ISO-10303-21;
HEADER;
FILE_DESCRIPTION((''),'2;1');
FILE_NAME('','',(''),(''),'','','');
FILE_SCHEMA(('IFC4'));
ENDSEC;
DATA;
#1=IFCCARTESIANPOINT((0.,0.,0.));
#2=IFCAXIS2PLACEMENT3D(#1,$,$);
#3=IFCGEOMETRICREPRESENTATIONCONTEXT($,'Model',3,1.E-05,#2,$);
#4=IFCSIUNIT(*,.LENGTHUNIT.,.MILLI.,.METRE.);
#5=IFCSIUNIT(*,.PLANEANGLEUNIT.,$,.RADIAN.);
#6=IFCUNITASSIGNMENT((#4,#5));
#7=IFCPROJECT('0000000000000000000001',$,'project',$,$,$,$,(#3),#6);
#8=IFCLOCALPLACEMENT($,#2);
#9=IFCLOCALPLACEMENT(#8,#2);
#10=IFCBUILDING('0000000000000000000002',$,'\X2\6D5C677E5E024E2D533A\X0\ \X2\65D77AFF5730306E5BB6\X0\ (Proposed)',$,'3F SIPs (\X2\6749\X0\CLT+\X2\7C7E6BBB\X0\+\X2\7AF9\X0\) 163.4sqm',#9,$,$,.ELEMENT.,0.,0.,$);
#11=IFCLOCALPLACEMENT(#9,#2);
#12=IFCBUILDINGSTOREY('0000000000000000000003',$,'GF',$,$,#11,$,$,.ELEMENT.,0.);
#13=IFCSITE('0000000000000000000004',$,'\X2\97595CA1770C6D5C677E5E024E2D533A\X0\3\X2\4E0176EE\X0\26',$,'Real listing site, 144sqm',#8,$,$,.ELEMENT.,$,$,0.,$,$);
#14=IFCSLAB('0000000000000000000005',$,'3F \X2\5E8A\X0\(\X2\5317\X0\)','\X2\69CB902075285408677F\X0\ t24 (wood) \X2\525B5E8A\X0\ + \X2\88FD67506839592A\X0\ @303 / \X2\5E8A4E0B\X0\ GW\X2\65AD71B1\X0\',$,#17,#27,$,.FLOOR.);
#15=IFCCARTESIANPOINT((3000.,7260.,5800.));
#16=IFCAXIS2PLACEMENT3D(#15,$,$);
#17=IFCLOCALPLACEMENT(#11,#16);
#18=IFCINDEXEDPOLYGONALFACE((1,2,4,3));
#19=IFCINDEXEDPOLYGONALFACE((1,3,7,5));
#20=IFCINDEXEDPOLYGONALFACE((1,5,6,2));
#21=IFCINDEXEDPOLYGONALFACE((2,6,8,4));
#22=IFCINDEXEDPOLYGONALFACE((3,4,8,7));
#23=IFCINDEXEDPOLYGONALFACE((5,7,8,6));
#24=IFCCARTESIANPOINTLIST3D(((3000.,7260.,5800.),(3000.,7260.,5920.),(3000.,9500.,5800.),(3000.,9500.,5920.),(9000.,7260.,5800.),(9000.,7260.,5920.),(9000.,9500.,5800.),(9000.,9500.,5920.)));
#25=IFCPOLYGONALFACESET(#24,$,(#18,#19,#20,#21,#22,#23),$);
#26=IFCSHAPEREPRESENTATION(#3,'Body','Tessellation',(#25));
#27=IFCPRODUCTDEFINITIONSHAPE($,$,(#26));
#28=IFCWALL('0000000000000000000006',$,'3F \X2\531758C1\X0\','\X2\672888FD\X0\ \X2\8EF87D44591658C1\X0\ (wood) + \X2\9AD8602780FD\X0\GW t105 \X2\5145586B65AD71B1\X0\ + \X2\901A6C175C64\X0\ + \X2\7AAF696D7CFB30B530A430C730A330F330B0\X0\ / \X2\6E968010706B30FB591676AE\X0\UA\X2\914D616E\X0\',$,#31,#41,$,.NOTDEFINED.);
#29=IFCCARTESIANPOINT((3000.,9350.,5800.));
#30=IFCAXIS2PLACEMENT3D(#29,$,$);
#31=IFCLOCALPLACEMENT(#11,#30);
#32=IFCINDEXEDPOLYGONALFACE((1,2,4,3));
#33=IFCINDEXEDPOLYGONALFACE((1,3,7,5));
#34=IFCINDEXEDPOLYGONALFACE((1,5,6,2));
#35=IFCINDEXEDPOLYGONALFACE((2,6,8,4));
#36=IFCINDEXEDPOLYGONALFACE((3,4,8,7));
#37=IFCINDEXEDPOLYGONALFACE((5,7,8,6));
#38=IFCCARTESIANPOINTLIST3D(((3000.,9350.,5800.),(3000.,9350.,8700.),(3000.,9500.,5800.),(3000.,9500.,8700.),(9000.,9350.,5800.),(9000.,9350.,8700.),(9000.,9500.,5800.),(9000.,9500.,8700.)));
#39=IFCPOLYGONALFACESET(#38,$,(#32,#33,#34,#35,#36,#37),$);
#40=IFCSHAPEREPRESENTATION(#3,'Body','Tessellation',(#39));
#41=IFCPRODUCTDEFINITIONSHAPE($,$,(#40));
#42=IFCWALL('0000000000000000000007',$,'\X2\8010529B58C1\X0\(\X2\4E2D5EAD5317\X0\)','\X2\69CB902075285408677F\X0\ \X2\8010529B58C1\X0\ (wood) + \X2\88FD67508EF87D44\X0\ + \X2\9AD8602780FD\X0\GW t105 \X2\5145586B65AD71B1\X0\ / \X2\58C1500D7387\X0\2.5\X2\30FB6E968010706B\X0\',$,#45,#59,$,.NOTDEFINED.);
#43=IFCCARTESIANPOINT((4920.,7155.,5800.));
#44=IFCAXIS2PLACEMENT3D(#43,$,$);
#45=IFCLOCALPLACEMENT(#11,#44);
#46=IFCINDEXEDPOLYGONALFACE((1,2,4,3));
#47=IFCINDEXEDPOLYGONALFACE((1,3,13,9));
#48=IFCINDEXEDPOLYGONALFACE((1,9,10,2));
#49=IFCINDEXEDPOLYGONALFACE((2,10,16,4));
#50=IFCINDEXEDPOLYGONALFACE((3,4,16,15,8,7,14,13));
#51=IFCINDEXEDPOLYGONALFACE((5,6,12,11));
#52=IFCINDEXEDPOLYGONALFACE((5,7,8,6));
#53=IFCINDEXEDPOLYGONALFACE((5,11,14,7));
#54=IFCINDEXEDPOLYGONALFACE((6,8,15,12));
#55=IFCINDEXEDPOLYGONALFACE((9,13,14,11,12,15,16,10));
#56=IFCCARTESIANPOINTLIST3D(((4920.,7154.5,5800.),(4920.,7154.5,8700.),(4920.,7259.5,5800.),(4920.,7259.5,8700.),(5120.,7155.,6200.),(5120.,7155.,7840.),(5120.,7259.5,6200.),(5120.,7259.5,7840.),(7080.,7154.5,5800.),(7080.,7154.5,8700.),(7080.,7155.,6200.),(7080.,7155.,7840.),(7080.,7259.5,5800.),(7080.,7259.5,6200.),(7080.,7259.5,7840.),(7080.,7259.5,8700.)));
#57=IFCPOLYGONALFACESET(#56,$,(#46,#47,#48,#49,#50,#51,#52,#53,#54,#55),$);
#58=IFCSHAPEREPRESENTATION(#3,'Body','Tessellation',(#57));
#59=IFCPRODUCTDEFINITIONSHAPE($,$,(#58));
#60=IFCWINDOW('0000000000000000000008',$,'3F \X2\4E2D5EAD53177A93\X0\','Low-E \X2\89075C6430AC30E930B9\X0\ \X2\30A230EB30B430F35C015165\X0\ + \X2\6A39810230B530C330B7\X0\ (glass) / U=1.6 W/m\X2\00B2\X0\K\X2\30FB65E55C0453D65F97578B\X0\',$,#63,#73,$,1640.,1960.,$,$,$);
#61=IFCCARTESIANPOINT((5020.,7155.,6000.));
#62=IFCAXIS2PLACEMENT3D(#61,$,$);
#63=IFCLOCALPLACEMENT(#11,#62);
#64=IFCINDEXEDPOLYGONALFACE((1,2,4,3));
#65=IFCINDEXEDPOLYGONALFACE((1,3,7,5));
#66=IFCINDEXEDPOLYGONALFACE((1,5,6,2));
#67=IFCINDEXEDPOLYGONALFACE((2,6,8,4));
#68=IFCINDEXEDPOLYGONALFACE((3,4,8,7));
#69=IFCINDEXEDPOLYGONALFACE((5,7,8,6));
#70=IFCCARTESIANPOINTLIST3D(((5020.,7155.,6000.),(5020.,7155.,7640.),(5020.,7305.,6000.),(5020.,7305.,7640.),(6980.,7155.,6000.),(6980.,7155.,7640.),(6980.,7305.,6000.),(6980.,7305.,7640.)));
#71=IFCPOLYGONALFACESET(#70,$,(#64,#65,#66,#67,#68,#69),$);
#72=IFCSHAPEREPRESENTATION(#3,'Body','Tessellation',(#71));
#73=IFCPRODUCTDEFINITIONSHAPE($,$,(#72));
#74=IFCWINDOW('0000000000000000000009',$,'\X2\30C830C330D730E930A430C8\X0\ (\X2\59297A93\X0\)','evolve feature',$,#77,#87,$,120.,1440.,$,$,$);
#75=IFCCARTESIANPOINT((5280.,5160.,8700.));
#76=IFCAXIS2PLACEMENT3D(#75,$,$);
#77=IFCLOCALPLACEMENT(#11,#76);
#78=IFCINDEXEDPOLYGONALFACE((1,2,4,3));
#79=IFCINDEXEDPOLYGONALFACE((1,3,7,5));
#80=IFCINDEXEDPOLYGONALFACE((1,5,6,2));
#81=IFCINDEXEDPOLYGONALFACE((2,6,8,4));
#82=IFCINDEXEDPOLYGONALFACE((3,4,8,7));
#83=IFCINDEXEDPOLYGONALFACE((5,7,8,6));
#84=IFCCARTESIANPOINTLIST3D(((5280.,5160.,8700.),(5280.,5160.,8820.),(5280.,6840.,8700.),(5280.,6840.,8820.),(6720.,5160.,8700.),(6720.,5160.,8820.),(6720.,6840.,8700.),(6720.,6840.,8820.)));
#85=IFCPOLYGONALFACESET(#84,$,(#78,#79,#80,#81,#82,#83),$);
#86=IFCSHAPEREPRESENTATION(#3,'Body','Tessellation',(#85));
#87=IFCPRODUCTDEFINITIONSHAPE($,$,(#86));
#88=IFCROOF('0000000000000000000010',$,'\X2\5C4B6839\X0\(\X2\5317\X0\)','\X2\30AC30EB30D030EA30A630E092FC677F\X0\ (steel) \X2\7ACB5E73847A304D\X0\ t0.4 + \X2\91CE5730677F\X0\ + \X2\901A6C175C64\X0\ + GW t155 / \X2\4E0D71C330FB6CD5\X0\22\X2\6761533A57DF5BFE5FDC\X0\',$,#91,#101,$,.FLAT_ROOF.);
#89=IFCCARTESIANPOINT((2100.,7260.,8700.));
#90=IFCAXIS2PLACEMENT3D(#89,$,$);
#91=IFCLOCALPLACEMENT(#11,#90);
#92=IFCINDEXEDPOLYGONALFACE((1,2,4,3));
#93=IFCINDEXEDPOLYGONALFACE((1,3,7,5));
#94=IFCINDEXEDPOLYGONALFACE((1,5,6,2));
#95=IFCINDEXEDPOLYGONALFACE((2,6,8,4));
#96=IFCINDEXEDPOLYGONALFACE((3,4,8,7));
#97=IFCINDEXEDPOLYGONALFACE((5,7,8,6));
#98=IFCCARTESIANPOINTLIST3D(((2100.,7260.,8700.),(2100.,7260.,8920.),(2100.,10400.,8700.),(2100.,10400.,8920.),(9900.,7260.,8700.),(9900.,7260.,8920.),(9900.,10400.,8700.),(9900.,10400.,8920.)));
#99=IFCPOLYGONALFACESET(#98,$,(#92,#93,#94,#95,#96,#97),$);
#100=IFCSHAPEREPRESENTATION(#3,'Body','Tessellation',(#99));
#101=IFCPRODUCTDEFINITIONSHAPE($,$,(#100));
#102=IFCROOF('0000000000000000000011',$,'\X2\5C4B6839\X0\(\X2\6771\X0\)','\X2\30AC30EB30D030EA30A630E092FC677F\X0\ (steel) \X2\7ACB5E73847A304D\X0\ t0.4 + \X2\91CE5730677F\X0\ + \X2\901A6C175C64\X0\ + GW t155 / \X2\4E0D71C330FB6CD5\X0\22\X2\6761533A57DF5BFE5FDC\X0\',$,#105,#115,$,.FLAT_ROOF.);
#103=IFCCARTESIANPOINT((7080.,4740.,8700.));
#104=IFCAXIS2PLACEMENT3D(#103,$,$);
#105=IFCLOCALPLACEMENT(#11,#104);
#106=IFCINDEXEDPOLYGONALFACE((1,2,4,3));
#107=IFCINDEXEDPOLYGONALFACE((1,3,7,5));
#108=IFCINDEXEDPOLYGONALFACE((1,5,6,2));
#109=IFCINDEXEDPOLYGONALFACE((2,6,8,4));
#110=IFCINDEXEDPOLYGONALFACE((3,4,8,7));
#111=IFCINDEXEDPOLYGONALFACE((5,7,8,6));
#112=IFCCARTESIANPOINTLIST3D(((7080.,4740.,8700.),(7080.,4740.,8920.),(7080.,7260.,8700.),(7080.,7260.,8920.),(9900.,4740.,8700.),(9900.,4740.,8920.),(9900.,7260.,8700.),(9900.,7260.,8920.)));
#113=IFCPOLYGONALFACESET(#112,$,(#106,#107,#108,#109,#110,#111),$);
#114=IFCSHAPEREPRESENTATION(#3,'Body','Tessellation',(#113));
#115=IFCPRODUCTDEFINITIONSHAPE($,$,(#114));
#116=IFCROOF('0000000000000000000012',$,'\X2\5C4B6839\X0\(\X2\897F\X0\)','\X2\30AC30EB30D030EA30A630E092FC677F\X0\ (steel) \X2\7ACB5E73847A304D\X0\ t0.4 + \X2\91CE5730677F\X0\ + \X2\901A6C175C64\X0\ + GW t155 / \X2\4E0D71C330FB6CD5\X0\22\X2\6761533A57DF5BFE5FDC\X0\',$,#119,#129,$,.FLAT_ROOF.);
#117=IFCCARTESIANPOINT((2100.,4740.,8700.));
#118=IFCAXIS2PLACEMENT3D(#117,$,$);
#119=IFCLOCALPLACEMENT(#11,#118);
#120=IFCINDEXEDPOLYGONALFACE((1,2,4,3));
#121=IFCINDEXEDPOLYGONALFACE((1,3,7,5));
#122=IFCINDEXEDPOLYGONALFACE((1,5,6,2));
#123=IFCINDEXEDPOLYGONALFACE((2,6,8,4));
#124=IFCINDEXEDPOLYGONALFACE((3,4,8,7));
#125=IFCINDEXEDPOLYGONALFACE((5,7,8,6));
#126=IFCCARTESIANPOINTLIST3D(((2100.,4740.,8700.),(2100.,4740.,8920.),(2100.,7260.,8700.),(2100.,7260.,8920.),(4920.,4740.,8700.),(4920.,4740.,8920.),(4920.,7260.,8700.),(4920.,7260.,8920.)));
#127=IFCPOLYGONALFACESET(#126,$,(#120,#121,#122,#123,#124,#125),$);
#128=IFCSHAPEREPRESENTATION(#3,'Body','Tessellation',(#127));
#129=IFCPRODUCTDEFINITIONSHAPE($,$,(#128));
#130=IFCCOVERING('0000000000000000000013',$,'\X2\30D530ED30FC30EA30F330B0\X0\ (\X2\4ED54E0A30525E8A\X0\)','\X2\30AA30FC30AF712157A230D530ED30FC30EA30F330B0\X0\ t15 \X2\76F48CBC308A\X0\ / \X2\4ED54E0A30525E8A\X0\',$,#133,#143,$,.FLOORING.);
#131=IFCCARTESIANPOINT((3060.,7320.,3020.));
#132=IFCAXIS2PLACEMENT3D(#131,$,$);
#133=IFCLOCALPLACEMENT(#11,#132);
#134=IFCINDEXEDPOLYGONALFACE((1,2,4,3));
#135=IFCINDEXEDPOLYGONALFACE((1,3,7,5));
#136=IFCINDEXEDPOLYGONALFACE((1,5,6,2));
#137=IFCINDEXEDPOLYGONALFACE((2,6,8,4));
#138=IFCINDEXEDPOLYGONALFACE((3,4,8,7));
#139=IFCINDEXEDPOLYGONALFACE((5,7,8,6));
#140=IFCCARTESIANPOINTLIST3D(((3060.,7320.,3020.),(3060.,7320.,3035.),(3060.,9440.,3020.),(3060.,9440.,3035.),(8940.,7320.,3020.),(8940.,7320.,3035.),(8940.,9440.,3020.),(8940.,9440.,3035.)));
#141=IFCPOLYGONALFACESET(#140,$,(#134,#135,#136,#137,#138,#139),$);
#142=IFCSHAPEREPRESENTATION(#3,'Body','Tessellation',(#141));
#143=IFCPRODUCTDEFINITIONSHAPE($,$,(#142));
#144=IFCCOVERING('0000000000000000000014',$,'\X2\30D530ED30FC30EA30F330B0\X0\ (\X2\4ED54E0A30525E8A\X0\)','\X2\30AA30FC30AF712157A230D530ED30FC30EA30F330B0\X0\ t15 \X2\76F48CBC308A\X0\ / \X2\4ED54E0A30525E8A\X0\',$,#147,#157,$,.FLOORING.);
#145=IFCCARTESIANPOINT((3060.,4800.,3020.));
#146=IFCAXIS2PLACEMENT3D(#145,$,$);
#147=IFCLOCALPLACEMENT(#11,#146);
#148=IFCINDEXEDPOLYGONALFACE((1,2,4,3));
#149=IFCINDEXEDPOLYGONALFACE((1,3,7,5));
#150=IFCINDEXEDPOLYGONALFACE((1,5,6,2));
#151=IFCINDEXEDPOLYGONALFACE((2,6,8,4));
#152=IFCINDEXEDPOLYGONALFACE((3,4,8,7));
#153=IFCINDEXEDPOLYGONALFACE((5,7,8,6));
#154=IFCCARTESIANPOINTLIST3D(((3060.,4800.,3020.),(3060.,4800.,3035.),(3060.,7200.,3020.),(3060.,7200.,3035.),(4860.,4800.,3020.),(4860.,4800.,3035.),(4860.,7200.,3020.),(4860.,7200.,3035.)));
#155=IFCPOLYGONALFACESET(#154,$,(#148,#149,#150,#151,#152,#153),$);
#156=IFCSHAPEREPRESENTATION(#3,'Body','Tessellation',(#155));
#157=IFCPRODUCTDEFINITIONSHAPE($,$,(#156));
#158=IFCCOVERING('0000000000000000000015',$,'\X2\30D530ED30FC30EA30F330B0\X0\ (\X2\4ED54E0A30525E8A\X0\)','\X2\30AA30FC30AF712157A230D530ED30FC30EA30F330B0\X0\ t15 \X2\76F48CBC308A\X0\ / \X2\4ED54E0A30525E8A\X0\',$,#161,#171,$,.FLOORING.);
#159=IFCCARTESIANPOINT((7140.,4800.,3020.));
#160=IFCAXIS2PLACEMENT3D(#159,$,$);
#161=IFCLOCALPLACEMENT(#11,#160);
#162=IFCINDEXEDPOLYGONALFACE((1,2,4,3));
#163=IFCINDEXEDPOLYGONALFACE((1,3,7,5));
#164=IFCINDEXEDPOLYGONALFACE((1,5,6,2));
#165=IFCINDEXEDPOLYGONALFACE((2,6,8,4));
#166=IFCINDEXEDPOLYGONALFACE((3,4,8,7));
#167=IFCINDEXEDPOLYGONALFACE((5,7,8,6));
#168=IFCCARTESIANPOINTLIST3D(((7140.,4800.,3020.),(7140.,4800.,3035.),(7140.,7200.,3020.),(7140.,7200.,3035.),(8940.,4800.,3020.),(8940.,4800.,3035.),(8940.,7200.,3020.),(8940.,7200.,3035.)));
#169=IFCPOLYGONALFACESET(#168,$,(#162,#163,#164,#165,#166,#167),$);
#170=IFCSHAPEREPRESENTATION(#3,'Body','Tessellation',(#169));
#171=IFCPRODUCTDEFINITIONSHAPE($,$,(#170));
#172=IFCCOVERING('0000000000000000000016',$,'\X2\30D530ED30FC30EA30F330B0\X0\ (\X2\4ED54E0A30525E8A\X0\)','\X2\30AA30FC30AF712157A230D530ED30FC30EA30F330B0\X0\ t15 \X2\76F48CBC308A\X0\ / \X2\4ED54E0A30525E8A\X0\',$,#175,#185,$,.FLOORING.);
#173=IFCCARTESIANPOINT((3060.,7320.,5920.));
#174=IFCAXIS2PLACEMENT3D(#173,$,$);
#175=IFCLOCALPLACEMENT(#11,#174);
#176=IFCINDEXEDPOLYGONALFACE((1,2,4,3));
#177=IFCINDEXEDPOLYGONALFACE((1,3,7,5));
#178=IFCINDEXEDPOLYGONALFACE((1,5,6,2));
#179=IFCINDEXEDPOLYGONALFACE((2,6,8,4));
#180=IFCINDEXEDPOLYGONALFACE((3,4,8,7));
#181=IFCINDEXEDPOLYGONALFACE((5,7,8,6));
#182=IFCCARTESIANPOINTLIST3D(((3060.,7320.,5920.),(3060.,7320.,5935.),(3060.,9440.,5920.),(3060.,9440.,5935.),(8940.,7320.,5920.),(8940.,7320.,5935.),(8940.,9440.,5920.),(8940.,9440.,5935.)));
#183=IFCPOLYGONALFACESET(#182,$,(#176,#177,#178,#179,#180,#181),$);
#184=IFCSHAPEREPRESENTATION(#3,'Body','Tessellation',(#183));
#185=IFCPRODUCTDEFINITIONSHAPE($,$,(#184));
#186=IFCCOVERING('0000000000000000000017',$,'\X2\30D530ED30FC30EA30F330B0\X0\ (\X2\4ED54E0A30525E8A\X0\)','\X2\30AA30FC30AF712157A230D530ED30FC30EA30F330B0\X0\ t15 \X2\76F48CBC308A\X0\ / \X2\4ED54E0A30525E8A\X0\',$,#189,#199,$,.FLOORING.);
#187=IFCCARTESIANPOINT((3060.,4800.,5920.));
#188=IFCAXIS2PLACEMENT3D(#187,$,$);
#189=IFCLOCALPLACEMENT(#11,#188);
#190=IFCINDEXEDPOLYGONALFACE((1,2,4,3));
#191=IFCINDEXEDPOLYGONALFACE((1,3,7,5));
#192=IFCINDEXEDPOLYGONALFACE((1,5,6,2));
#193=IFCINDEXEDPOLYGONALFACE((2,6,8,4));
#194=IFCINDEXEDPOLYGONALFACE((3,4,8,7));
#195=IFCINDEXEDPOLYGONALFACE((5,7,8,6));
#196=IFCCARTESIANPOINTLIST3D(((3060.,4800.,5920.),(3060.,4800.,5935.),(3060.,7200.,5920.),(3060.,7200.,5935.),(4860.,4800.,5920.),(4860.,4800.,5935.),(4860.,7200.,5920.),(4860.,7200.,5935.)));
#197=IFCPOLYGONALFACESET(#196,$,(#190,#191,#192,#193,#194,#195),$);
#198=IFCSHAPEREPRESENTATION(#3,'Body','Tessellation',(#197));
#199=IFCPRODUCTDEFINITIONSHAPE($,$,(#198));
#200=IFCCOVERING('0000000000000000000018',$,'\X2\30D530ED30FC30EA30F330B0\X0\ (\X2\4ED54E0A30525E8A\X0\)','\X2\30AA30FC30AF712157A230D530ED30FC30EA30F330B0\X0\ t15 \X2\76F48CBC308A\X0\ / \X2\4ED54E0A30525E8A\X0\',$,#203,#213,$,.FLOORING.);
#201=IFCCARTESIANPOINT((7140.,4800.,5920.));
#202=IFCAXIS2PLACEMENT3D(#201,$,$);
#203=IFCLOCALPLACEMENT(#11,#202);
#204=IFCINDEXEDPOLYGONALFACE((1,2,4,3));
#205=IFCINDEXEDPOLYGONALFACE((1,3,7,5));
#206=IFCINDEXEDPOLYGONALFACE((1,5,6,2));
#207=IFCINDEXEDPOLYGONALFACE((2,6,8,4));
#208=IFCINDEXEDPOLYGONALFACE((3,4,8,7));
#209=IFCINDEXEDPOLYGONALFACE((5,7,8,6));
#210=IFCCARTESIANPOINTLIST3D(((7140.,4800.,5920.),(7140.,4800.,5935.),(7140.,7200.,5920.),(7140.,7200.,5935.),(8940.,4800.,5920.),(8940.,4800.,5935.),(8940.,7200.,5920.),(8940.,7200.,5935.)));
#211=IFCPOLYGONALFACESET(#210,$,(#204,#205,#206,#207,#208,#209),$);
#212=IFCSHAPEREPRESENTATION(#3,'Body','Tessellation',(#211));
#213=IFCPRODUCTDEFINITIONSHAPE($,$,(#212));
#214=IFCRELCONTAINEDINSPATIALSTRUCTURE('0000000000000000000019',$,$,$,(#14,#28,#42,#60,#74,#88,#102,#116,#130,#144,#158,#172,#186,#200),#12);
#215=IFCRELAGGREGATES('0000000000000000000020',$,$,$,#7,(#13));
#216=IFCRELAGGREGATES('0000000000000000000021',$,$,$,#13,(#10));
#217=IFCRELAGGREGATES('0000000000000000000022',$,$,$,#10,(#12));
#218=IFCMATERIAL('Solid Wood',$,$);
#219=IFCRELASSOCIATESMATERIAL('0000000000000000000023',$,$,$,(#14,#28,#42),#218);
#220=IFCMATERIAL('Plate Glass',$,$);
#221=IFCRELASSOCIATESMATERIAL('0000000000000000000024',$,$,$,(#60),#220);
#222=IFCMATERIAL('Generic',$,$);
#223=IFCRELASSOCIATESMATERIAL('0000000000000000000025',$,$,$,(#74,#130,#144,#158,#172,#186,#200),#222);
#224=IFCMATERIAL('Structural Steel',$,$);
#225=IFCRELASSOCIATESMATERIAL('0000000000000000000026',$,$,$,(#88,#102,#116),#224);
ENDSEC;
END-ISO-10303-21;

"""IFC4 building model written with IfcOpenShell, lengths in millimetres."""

from ifc_helpers import new_model, si_unit, frame, frame_2d, origin, place, context, project, spatial, rectangle, extrude, material, element, fill, save


model = new_model("IFC4")

# Units and contexts
model_context = context("Model", 3, precision=1e-05, world=origin())
ifc_project = project(units=[si_unit("LENGTHUNIT", "METRE", prefix="MILLI"), si_unit("PLANEANGLEUNIT", "RADIAN")], contexts=[model_context])

# Site, building, storey
site_placement = place(None, origin())
site = spatial("IfcSite", under=ifc_project, at=site_placement, Name="静岡県浜松市中区3丁目26", ObjectType="Real listing site, 144sqm", CompositionType="ELEMENT", RefElevation=0.0)
building_placement = place(site_placement, origin())
building = spatial("IfcBuilding", under=site, at=building_placement, Name="浜松市中区 旗竿地の家 (Proposed)", ObjectType="3F SIPs (杉CLT+籾殻+竹) 163.4sqm", CompositionType="ELEMENT", ElevationOfRefHeight=0.0, ElevationOfTerrain=0.0)
storey_placement = place(building_placement, origin())
storey = spatial("IfcBuildingStorey", under=building, at=storey_placement, Name="GF", CompositionType="ELEMENT", Elevation=0.0)

# Slab
ifc_material_1 = material(Name="Solid Wood")
slab_placement = place(storey_placement, frame((3000.0, 7260.0, 5800.0)))
element("IfcSlab", 1, at=slab_placement, inside=storey, material=ifc_material_1, Name="3F 床(北)", Description="構造用合板 t24 (wood) 剛床 + 製材根太 @303 / 床下 GW断熱", PredefinedType="FLOOR", context=model_context, shape_type="SweptSolid", body=[
    extrude(rectangle(XDim=6000.0, YDim=2240.0, at=frame_2d((3000.0, 1120.0))), frame((3000.0, 7260.0, 5800.0)), (0.0, 0.0, 1.0), 120.0),
])

# Wall
wall_1_placement = place(storey_placement, frame((3000.0, 9350.0, 5800.0)))
element("IfcWall", 2, at=wall_1_placement, inside=storey, material=ifc_material_1, Name="3F 北壁", Description="木製 軸組外壁 (wood) + 高性能GW t105 充填断熱 + 通気層 + 窯業系サイディング / 準耐火・外皮UA配慮", PredefinedType="NOTDEFINED", context=model_context, shape_type="SweptSolid", body=[
    extrude(rectangle(XDim=6000.0, YDim=150.0, at=frame_2d((3000.0, 75.0))), frame((3000.0, 9350.0, 5800.0)), (0.0, 0.0, 1.0), 2900.0),
])

# Wall, opening, window
wall_2_placement = place(storey_placement, frame((4920.0, 7155.0, 5800.0)))
wall_2 = element("IfcWall", 3, at=wall_2_placement, inside=storey, material=ifc_material_1, Name="耐力壁(中庭北)", Description="構造用合板 耐力壁 (wood) + 製材軸組 + 高性能GW t105 充填断熱 / 壁倍率2.5・準耐火", PredefinedType="NOTDEFINED", context=model_context, shape_type="SweptSolid", body=[
    extrude(rectangle(XDim=2160.0, YDim=105.0, at=frame_2d((1080.0, 52.0))), frame((4920.0, 7155.0, 5800.0)), (0.0, 0.0, 1.0), 2900.0),
])
opening_placement = place(storey_placement, frame((5020.0, 7155.0, 6000.0)))
opening = element("IfcOpeningElement", 4, at=opening_placement, cuts=wall_2, PredefinedType="NOTDEFINED", context=model_context, shape_type="SweptSolid", body=[
    extrude(rectangle(XDim=1960.0, YDim=150.0, at=frame_2d((980.0, 75.0))), frame((5020.0, 7155.0, 6000.0)), (0.0, 0.0, 1.0), 1640.0),
])
ifc_material_2 = material(Name="Plate Glass")
window_1_placement = place(storey_placement, frame((5020.0, 7155.0, 6000.0)))
window_1 = element("IfcWindow", 5, at=window_1_placement, inside=storey, material=ifc_material_2, Name="3F 中庭北窓", Description="Low-E 複層ガラス アルゴン封入 + 樹脂サッシ (glass) / U=1.6 W/m²K・日射取得型", OverallHeight=1640.0, OverallWidth=1960.0, context=model_context, shape_type="SweptSolid", body=[
    extrude(rectangle(XDim=1960.0, YDim=150.0, at=frame_2d((980.0, 75.0))), frame((5020.0, 7155.0, 6000.0)), (0.0, 0.0, 1.0), 1640.0),
])
fill(opening, window_1)

# Window
ifc_material_3 = material(Name="Generic")
window_2_placement = place(storey_placement, frame((5280.0, 5160.0, 8700.0)))
element("IfcWindow", 6, at=window_2_placement, inside=storey, material=ifc_material_3, Name="トップライト (天窓)", Description="evolve feature", OverallHeight=120.0, OverallWidth=1440.0, context=model_context, shape_type="SweptSolid", body=[
    extrude(rectangle(XDim=1440.0, YDim=1680.0, at=frame_2d((720.0, 840.0))), frame((5280.0, 5160.0, 8700.0)), (0.0, 0.0, 1.0), 120.0),
])

# Roofs
ifc_material_4 = material(Name="Structural Steel")
roof_1_placement = place(storey_placement, frame((2100.0, 7260.0, 8700.0)))
element("IfcRoof", 7, at=roof_1_placement, inside=storey, material=ifc_material_4, Name="屋根(北)", Description="ガルバリウム鋼板 (steel) 立平葺き t0.4 + 野地板 + 通気層 + GW t155 / 不燃・法22条区域対応", PredefinedType="FLAT_ROOF", context=model_context, shape_type="SweptSolid", body=[
    extrude(rectangle(XDim=7800.0, YDim=3140.0, at=frame_2d((3900.0, 1570.0))), frame((2100.0, 7260.0, 8700.0)), (0.0, 0.0, 1.0), 220.0),
])
roof_2_placement = place(storey_placement, frame((7080.0, 4740.0, 8700.0)))
element("IfcRoof", 8, at=roof_2_placement, inside=storey, material=ifc_material_4, Name="屋根(東)", Description="ガルバリウム鋼板 (steel) 立平葺き t0.4 + 野地板 + 通気層 + GW t155 / 不燃・法22条区域対応", PredefinedType="FLAT_ROOF", context=model_context, shape_type="SweptSolid", body=[
    extrude(rectangle(XDim=2820.0, YDim=2520.0, at=frame_2d((1410.0, 1260.0))), frame((7080.0, 4740.0, 8700.0)), (0.0, 0.0, 1.0), 220.0),
])
roof_3_placement = place(storey_placement, frame((2100.0, 4740.0, 8700.0)))
element("IfcRoof", 9, at=roof_3_placement, inside=storey, material=ifc_material_4, Name="屋根(西)", Description="ガルバリウム鋼板 (steel) 立平葺き t0.4 + 野地板 + 通気層 + GW t155 / 不燃・法22条区域対応", PredefinedType="FLAT_ROOF", context=model_context, shape_type="SweptSolid", body=[
    extrude(rectangle(XDim=2820.0, YDim=2520.0, at=frame_2d((1410.0, 1260.0))), frame((2100.0, 4740.0, 8700.0)), (0.0, 0.0, 1.0), 220.0),
])

# Coverings
covering_1_placement = place(storey_placement, frame((3060.0, 7320.0, 3020.0)))
element("IfcCovering", 10, at=covering_1_placement, inside=storey, material=ifc_material_3, Name="フローリング (仕上げ床)", Description="オーク無垢フローリング t15 直貼り / 仕上げ床", PredefinedType="FLOORING", context=model_context, shape_type="SweptSolid", body=[
    extrude(rectangle(XDim=5880.0, YDim=2120.0, at=frame_2d((2940.0, 1060.0))), frame((3060.0, 7320.0, 3020.0)), (0.0, 0.0, 1.0), 15.0),
])
covering_2_placement = place(storey_placement, frame((3060.0, 4800.0, 3020.0)))
element("IfcCovering", 11, at=covering_2_placement, inside=storey, material=ifc_material_3, Name="フローリング (仕上げ床)", Description="オーク無垢フローリング t15 直貼り / 仕上げ床", PredefinedType="FLOORING", context=model_context, shape_type="SweptSolid", body=[
    extrude(rectangle(XDim=1800.0, YDim=2400.0, at=frame_2d((900.0, 1200.0))), frame((3060.0, 4800.0, 3020.0)), (0.0, 0.0, 1.0), 15.0),
])
covering_3_placement = place(storey_placement, frame((7140.0, 4800.0, 3020.0)))
element("IfcCovering", 12, at=covering_3_placement, inside=storey, material=ifc_material_3, Name="フローリング (仕上げ床)", Description="オーク無垢フローリング t15 直貼り / 仕上げ床", PredefinedType="FLOORING", context=model_context, shape_type="SweptSolid", body=[
    extrude(rectangle(XDim=1800.0, YDim=2400.0, at=frame_2d((900.0, 1200.0))), frame((7140.0, 4800.0, 3020.0)), (0.0, 0.0, 1.0), 15.0),
])
covering_4_placement = place(storey_placement, frame((3060.0, 7320.0, 5920.0)))
element("IfcCovering", 13, at=covering_4_placement, inside=storey, material=ifc_material_3, Name="フローリング (仕上げ床)", Description="オーク無垢フローリング t15 直貼り / 仕上げ床", PredefinedType="FLOORING", context=model_context, shape_type="SweptSolid", body=[
    extrude(rectangle(XDim=5880.0, YDim=2120.0, at=frame_2d((2940.0, 1060.0))), frame((3060.0, 7320.0, 5920.0)), (0.0, 0.0, 1.0), 15.0),
])
covering_5_placement = place(storey_placement, frame((3060.0, 4800.0, 5920.0)))
element("IfcCovering", 14, at=covering_5_placement, inside=storey, material=ifc_material_3, Name="フローリング (仕上げ床)", Description="オーク無垢フローリング t15 直貼り / 仕上げ床", PredefinedType="FLOORING", context=model_context, shape_type="SweptSolid", body=[
    extrude(rectangle(XDim=1800.0, YDim=2400.0, at=frame_2d((900.0, 1200.0))), frame((3060.0, 4800.0, 5920.0)), (0.0, 0.0, 1.0), 15.0),
])
covering_6_placement = place(storey_placement, frame((7140.0, 4800.0, 5920.0)))
element("IfcCovering", 15, at=covering_6_placement, inside=storey, material=ifc_material_3, Name="フローリング (仕上げ床)", Description="オーク無垢フローリング t15 直貼り / 仕上げ床", PredefinedType="FLOORING", context=model_context, shape_type="SweptSolid", body=[
    extrude(rectangle(XDim=1800.0, YDim=2400.0, at=frame_2d((900.0, 1200.0))), frame((7140.0, 4800.0, 5920.0)), (0.0, 0.0, 1.0), 15.0),
])

save(model, "model.ifc")
